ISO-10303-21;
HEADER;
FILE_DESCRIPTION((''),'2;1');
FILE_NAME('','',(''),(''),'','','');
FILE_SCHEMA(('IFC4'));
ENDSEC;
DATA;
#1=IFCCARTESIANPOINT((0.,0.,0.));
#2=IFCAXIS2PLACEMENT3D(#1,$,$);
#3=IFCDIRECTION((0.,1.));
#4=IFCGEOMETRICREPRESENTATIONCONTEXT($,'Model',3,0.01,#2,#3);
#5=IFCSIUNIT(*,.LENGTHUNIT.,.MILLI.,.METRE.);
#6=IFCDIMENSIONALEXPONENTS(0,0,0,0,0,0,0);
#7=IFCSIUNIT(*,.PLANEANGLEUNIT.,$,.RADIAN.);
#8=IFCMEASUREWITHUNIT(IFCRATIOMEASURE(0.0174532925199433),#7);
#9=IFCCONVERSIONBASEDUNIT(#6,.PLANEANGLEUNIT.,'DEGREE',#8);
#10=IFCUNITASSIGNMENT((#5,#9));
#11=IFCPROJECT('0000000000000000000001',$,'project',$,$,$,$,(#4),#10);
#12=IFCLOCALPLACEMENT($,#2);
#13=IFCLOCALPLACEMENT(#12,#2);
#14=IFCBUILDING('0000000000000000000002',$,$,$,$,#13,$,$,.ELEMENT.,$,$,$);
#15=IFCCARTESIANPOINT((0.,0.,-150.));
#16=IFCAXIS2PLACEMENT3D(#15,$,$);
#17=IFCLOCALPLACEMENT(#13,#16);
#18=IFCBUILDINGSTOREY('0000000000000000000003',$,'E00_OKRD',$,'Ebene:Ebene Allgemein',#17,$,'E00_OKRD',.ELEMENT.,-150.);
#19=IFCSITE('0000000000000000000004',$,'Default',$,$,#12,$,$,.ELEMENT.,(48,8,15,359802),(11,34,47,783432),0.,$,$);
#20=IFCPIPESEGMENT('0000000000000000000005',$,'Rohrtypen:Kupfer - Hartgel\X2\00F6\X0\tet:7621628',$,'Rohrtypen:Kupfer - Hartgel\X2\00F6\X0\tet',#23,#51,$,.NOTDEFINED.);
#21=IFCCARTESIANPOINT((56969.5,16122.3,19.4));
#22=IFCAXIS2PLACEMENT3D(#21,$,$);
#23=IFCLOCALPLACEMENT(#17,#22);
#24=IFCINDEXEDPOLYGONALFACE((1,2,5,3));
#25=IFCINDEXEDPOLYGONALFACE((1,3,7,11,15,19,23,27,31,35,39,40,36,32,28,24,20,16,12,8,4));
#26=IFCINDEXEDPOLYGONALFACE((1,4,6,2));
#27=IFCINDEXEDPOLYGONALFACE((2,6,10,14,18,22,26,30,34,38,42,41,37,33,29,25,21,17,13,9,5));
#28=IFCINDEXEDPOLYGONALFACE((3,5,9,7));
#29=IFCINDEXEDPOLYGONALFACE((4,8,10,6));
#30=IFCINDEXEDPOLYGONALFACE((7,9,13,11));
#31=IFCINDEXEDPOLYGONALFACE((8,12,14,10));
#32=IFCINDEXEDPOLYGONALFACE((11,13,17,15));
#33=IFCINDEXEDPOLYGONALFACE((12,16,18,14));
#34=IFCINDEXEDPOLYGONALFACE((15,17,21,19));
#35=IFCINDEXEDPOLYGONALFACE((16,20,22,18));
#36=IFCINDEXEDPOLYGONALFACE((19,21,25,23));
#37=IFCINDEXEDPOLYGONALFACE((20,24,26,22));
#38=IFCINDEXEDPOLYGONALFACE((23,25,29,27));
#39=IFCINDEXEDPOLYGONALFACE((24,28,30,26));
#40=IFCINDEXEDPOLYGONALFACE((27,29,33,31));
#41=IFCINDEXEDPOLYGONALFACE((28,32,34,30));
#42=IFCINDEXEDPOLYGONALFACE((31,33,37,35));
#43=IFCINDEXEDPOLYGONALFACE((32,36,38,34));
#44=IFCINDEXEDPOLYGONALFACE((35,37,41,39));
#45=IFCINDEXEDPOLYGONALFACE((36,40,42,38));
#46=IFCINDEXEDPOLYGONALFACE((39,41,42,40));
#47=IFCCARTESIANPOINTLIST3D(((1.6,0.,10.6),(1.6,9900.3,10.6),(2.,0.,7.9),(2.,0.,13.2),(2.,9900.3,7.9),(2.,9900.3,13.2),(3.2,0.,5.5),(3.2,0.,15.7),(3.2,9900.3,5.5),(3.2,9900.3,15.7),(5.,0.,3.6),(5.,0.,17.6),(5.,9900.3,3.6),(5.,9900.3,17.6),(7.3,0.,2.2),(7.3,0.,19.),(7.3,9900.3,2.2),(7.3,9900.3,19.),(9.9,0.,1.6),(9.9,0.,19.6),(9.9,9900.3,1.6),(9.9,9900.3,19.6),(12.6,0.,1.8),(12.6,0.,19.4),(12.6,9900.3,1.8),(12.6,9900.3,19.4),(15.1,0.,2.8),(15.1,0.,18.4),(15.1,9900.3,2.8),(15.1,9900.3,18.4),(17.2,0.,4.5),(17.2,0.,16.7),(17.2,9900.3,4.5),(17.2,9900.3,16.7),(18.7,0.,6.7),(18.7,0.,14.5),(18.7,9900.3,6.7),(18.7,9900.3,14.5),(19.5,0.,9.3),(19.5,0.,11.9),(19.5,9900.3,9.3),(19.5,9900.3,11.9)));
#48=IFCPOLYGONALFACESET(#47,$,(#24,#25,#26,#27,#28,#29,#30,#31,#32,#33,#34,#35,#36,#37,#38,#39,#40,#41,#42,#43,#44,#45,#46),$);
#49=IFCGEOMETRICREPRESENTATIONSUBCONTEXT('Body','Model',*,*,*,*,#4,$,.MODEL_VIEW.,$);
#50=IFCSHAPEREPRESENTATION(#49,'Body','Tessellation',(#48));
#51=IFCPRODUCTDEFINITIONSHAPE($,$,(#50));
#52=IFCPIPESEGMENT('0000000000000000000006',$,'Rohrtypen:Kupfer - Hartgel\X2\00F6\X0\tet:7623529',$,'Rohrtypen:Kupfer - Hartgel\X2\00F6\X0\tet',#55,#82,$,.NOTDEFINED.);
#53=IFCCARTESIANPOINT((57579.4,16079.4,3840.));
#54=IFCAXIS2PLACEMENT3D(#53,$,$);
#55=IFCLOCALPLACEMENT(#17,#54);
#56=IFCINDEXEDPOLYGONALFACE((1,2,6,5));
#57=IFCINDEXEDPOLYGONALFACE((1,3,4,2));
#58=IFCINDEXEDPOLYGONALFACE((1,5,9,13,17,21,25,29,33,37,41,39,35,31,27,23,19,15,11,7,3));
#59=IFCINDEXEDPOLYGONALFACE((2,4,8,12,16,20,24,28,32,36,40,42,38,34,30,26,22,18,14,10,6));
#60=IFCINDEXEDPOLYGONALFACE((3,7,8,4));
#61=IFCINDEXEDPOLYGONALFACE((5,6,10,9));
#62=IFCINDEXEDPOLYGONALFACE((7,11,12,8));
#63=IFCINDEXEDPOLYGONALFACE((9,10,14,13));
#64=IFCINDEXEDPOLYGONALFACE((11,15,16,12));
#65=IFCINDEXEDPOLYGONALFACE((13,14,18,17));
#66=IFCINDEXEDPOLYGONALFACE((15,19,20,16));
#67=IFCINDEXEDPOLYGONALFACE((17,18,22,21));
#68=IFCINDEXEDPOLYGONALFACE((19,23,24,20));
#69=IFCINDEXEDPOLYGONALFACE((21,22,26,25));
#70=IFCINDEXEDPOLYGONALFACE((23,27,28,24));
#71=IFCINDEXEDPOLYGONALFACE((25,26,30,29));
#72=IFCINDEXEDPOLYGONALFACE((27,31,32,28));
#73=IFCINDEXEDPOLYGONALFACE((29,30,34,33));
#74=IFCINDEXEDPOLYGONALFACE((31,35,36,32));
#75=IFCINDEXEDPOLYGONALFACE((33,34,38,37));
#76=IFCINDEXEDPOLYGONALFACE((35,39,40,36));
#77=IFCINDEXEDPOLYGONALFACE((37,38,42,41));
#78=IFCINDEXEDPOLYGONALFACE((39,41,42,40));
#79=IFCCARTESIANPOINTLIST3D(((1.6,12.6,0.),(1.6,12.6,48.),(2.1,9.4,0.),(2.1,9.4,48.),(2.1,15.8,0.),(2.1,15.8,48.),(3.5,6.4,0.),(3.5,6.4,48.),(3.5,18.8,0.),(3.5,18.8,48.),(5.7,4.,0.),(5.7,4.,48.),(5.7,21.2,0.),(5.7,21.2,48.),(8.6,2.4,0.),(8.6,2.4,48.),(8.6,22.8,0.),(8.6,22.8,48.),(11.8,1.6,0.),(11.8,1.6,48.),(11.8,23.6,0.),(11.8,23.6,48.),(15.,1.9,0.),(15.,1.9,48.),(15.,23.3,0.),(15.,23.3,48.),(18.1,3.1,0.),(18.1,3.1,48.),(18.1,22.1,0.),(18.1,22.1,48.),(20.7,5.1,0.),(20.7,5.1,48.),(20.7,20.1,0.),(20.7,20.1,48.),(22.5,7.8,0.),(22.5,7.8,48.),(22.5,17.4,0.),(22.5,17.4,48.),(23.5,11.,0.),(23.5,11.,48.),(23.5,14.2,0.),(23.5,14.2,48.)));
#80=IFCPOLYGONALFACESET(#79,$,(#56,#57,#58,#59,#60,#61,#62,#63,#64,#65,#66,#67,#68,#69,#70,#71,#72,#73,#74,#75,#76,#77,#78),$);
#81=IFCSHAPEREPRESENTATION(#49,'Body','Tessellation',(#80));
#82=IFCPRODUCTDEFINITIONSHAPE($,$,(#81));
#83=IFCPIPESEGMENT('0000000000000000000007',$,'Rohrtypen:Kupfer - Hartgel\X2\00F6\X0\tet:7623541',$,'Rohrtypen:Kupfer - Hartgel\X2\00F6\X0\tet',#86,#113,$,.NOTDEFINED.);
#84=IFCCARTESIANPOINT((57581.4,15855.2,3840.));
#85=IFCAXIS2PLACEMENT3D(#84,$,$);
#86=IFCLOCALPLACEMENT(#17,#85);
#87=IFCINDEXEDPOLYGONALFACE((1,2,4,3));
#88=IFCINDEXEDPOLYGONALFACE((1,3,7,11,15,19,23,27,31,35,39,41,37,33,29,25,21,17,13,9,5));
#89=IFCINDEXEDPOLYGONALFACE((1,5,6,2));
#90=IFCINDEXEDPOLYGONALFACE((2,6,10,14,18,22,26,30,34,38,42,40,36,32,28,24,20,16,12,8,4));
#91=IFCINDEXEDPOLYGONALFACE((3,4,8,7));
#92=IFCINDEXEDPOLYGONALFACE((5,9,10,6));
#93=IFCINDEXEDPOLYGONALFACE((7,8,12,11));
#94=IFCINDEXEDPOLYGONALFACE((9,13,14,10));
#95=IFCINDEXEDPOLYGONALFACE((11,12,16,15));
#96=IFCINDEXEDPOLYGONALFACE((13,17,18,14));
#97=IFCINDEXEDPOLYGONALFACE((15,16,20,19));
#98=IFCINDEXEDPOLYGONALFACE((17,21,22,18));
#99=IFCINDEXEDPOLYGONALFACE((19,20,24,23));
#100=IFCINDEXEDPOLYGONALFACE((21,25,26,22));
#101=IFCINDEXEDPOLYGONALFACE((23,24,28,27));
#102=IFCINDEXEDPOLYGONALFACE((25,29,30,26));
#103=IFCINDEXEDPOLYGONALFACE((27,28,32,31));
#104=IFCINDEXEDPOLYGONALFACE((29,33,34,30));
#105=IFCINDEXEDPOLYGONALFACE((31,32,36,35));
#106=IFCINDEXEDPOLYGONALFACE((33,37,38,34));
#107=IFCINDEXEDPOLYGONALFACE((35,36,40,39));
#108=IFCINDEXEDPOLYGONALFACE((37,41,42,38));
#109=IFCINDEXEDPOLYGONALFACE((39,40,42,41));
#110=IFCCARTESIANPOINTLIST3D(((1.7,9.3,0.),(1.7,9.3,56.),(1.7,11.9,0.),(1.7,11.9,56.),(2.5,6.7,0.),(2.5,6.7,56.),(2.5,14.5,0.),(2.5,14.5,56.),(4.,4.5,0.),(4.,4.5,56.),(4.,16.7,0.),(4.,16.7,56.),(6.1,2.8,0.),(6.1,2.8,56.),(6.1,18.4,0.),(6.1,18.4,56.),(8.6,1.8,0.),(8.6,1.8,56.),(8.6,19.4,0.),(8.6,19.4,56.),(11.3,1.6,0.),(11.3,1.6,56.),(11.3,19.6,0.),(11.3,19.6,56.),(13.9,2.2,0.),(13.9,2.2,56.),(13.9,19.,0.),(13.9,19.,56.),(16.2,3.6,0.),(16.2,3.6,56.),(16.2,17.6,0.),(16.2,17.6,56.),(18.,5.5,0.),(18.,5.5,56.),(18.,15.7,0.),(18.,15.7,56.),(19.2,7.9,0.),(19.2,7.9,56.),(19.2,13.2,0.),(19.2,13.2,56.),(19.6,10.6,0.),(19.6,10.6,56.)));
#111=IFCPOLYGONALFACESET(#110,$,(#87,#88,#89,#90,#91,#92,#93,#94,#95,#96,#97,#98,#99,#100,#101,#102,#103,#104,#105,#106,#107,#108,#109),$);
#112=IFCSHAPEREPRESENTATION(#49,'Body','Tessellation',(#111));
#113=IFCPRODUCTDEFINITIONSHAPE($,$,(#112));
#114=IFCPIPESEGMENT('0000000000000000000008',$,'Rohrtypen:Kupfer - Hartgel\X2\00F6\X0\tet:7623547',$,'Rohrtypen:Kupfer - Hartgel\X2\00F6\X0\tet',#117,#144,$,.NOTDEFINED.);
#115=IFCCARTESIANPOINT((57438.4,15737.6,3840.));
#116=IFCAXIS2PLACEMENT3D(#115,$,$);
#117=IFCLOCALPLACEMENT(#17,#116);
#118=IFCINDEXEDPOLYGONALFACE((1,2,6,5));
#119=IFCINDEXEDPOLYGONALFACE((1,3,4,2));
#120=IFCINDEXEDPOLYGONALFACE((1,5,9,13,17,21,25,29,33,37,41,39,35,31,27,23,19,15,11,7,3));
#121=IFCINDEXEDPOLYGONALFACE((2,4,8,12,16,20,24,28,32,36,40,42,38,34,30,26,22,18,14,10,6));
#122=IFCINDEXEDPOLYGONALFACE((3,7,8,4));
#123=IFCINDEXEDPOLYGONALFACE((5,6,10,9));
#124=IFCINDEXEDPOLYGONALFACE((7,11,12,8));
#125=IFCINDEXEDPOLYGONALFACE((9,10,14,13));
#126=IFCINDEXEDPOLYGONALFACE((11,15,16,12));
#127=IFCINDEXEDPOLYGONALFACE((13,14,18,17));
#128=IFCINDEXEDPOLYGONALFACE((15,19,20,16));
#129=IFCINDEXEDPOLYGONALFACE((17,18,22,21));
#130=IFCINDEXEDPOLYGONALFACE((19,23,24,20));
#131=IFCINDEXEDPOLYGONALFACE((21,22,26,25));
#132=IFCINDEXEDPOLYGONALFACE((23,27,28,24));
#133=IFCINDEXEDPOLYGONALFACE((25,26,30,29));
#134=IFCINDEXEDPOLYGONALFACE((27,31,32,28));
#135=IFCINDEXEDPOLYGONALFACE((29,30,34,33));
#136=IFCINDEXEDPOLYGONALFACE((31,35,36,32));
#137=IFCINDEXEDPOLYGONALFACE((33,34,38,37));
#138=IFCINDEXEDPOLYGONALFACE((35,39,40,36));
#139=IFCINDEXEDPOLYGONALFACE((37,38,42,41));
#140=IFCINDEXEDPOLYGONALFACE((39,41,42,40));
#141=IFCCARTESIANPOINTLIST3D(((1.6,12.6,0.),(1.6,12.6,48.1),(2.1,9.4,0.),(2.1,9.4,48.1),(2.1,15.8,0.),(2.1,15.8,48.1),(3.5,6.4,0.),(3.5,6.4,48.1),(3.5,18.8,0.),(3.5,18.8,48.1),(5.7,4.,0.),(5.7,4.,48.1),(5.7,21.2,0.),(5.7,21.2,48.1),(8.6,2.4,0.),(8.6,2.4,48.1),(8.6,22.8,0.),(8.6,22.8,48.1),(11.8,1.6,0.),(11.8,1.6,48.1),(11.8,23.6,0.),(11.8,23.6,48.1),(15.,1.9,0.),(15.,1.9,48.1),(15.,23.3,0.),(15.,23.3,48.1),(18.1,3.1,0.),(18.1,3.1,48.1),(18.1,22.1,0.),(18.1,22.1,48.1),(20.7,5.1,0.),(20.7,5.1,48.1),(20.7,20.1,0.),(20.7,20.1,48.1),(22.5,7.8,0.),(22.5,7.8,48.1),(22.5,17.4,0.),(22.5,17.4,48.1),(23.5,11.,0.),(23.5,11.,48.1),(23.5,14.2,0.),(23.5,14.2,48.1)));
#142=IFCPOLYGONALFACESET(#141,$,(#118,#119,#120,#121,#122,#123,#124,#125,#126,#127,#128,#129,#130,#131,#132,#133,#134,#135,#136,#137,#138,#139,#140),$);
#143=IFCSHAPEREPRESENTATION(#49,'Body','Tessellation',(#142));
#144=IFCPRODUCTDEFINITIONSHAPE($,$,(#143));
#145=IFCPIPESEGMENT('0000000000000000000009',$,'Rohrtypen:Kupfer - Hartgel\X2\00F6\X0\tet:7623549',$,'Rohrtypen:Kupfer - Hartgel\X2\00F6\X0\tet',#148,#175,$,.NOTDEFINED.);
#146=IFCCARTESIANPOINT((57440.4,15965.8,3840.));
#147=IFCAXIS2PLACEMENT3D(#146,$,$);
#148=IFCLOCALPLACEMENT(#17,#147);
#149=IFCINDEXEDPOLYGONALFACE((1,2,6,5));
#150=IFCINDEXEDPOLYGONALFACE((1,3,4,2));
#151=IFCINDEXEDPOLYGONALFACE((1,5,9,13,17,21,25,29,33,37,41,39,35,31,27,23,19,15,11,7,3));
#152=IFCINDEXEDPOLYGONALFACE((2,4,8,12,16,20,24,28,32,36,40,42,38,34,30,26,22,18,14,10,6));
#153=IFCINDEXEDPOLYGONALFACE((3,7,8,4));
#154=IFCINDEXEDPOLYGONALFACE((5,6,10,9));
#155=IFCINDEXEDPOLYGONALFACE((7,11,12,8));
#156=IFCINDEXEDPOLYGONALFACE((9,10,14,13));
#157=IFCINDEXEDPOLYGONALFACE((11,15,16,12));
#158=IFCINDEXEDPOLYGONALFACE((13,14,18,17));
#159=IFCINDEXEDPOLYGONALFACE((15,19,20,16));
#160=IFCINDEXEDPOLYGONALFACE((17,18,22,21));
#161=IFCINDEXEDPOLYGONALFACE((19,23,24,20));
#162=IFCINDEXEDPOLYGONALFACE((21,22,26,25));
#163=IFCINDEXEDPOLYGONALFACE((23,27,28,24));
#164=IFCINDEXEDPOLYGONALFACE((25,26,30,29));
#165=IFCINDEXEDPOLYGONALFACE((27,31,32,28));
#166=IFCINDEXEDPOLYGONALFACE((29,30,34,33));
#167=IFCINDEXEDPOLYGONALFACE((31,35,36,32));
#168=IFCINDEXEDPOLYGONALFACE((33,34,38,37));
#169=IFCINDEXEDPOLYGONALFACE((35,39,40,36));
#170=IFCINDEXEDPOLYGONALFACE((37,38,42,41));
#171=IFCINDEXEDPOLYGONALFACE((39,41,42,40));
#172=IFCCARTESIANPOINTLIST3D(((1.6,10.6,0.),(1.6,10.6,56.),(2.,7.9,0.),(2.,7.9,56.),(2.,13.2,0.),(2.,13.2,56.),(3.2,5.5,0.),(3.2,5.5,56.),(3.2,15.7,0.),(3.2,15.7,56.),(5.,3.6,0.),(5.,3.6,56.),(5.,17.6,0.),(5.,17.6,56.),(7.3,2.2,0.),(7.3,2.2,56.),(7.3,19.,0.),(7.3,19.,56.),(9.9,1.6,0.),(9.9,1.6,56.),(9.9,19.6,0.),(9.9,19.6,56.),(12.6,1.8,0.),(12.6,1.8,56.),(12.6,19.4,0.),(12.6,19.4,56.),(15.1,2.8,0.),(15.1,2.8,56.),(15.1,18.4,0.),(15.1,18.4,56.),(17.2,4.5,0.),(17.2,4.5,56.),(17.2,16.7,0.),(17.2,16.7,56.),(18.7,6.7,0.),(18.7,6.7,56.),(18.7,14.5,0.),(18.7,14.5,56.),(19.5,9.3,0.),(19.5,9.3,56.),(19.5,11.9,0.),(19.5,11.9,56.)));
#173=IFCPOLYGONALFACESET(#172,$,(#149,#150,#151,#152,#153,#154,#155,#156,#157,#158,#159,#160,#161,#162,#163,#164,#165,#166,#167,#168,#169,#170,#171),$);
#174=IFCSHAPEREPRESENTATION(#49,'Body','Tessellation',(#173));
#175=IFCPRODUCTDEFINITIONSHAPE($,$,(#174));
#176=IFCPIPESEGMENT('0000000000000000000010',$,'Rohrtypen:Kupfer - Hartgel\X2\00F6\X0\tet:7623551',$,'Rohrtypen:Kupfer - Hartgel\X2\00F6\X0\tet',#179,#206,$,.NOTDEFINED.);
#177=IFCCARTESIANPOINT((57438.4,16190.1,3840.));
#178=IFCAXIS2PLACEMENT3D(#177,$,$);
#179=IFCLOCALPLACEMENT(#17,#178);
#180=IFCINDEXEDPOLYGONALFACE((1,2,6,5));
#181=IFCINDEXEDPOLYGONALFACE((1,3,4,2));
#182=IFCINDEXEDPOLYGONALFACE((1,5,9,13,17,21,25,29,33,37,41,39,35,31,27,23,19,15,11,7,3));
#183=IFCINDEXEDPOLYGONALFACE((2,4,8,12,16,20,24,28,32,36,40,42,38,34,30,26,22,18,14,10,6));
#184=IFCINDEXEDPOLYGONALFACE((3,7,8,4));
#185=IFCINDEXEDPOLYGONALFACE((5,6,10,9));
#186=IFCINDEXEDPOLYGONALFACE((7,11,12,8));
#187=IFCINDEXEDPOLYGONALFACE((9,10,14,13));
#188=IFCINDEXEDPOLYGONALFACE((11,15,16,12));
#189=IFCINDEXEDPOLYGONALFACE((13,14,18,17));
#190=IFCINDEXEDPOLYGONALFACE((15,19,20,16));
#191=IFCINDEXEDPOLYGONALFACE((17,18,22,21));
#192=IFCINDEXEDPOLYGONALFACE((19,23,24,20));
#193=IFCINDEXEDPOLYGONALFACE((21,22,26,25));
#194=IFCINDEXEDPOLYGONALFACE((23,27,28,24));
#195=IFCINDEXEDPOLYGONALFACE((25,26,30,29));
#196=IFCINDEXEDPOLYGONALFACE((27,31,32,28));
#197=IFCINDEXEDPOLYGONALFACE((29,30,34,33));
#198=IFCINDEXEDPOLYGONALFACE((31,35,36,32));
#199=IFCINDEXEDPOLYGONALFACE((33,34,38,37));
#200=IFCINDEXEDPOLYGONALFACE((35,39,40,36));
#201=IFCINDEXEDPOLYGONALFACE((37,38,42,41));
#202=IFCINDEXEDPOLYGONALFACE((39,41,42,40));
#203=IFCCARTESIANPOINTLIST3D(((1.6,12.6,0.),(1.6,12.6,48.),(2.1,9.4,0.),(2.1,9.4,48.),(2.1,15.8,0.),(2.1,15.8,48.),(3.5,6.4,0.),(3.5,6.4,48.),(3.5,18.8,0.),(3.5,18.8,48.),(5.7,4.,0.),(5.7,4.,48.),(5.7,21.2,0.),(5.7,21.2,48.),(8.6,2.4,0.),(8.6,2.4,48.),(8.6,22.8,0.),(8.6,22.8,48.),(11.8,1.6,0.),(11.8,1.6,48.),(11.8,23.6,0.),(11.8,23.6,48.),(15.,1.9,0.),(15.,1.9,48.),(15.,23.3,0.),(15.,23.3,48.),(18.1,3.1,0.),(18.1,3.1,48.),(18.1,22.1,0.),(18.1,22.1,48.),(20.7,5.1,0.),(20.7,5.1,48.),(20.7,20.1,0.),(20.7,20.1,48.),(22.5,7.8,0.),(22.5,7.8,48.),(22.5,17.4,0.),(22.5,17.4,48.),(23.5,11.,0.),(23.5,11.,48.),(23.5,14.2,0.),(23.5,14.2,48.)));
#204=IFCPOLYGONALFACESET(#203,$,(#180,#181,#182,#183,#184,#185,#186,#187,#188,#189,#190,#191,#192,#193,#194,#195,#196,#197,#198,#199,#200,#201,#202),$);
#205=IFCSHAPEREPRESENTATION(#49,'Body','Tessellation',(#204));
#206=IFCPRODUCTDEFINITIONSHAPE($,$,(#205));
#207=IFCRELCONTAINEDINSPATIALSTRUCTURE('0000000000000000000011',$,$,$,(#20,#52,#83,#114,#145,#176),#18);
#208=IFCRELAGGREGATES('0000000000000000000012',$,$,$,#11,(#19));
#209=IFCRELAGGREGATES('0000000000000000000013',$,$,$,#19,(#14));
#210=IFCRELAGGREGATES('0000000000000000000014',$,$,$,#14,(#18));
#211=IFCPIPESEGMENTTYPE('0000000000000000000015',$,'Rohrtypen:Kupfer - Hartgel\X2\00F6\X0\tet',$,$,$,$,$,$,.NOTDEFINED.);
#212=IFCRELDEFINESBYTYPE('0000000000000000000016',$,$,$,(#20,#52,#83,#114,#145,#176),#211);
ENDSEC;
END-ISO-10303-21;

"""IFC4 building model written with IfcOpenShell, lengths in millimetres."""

from ifc_helpers import new_model, entity, si_unit, converted_unit, direction, frame, frame_2d, origin, origin_2d_with_axis, place, context, subcontext, project, spatial, circle, extrude, type_object, element, save


model = new_model("IFC4")

# Units and contexts
model_context = context("Model", 3, precision=0.01, world=origin(), true_north=direction((0.0, 1.0)))
body_context = subcontext(model_context, "Body", "Model", "MODEL_VIEW")
ifc_project = project(units=[si_unit("LENGTHUNIT", "METRE", prefix="MILLI"), converted_unit("PLANEANGLEUNIT", "DEGREE", entity("IfcRatioMeasure", 0.0174532925199433), si_unit("PLANEANGLEUNIT", "RADIAN"), dimensions=[0, 0, 0, 0, 0, 0, 0])], contexts=[model_context])

# Site, building, storey
site_placement = place(None, origin())
site = spatial("IfcSite", under=ifc_project, at=site_placement, Name="Default", CompositionType="ELEMENT", RefLatitude=(48, 8, 15, 359802), RefLongitude=(11, 34, 47, 783432), RefElevation=0.0)
building_placement = place(site_placement, origin())
building = spatial("IfcBuilding", under=site, at=building_placement, CompositionType="ELEMENT")
storey_placement = place(building_placement, frame((0.0, 0.0, -150.0)))
storey = spatial("IfcBuildingStorey", under=building, at=storey_placement, Name="E00_OKRD", ObjectType="Ebene:Ebene Allgemein", LongName="E00_OKRD", CompositionType="ELEMENT", Elevation=-150.0)

# Pipe segments
pipe_segment_type = type_object("IfcPipeSegmentType", Name="Rohrtypen:Kupfer - Hartgelötet", PredefinedType="NOTDEFINED")
pipe_segment_1_placement = place(storey_placement, frame((56969.5, 16122.3, 19.4)))
element("IfcPipeSegment", 1, at=pipe_segment_1_placement, inside=storey, type_object=pipe_segment_type, Name="Rohrtypen:Kupfer - Hartgelötet:7621628", ObjectType="Rohrtypen:Kupfer - Hartgelötet", PredefinedType="NOTDEFINED", context=body_context, shape_type="SweptSolid", body=[
    extrude(circle(Radius=9.0, at=frame_2d((0.0, 0.0), x_axis=(1.0, 0.0))), frame((10.6, 0.0, 10.6), z_axis=(0.0, 1.0, 0.0), x_axis=(-1.0, 0.0, 0.0)), (0.0, 0.0, 1.0), 9900.3),
])
pipe_segment_2_placement = place(storey_placement, frame((57579.4, 16079.4, 3840.0)))
element("IfcPipeSegment", 2, at=pipe_segment_2_placement, inside=storey, type_object=pipe_segment_type, Name="Rohrtypen:Kupfer - Hartgelötet:7623529", ObjectType="Rohrtypen:Kupfer - Hartgelötet", PredefinedType="NOTDEFINED", context=body_context, shape_type="SweptSolid", body=[
    extrude(circle(Radius=11.0, at=frame_2d((0.0, 0.0), x_axis=(1.0, 0.0))), frame((12.6, 12.6, 0.0), z_axis=(0.0, 0.0, 1.0), x_axis=(-1.0, 0.0, 0.0)), (0.0, 0.0, 1.0), 48.0),
])
pipe_segment_3_placement = place(storey_placement, frame((57581.4, 15855.2, 3840.0)))
element("IfcPipeSegment", 3, at=pipe_segment_3_placement, inside=storey, type_object=pipe_segment_type, Name="Rohrtypen:Kupfer - Hartgelötet:7623541", ObjectType="Rohrtypen:Kupfer - Hartgelötet", PredefinedType="NOTDEFINED", context=body_context, shape_type="SweptSolid", body=[
    extrude(circle(Radius=9.0, at=frame_2d((0.0, 0.0), x_axis=(1.0, 0.0))), frame((10.6, 10.6, 0.0)), (0.0, 0.0, 1.0), 56.0),
])
pipe_segment_4_placement = place(storey_placement, frame((57438.4, 15737.6, 3840.0)))
element("IfcPipeSegment", 4, at=pipe_segment_4_placement, inside=storey, type_object=pipe_segment_type, Name="Rohrtypen:Kupfer - Hartgelötet:7623547", ObjectType="Rohrtypen:Kupfer - Hartgelötet", PredefinedType="NOTDEFINED", context=body_context, shape_type="SweptSolid", body=[
    extrude(circle(Radius=11.0, at=frame_2d((0.0, 0.0), x_axis=(1.0, 0.0))), frame((12.6, 12.6, 0.0), z_axis=(0.0, 0.0, 1.0), x_axis=(-1.0, 0.0, 0.0)), (0.0, 0.0, 1.0), 48.1),
])
pipe_segment_5_placement = place(storey_placement, frame((57440.4, 15965.8, 3840.0)))
element("IfcPipeSegment", 5, at=pipe_segment_5_placement, inside=storey, type_object=pipe_segment_type, Name="Rohrtypen:Kupfer - Hartgelötet:7623549", ObjectType="Rohrtypen:Kupfer - Hartgelötet", PredefinedType="NOTDEFINED", context=body_context, shape_type="SweptSolid", body=[
    extrude(circle(Radius=9.0, at=origin_2d_with_axis()), frame((10.6, 10.6, 0.0), z_axis=(0.0, 0.0, 1.0), x_axis=(-1.0, 0.0, 0.0)), (0.0, 0.0, 1.0), 56.0),
])
pipe_segment_6_placement = place(storey_placement, frame((57438.4, 16190.1, 3840.0)))
element("IfcPipeSegment", 6, at=pipe_segment_6_placement, inside=storey, type_object=pipe_segment_type, Name="Rohrtypen:Kupfer - Hartgelötet:7623551", ObjectType="Rohrtypen:Kupfer - Hartgelötet", PredefinedType="NOTDEFINED", context=body_context, shape_type="SweptSolid", body=[
    extrude(circle(Radius=11.0, at=frame_2d((0.0, 0.0), x_axis=(1.0, 0.0))), frame((12.6, 12.6, 0.0), z_axis=(0.0, 0.0, 1.0), x_axis=(-1.0, 0.0, 0.0)), (0.0, 0.0, 1.0), 48.0),
])

save(model, "model.ifc")
